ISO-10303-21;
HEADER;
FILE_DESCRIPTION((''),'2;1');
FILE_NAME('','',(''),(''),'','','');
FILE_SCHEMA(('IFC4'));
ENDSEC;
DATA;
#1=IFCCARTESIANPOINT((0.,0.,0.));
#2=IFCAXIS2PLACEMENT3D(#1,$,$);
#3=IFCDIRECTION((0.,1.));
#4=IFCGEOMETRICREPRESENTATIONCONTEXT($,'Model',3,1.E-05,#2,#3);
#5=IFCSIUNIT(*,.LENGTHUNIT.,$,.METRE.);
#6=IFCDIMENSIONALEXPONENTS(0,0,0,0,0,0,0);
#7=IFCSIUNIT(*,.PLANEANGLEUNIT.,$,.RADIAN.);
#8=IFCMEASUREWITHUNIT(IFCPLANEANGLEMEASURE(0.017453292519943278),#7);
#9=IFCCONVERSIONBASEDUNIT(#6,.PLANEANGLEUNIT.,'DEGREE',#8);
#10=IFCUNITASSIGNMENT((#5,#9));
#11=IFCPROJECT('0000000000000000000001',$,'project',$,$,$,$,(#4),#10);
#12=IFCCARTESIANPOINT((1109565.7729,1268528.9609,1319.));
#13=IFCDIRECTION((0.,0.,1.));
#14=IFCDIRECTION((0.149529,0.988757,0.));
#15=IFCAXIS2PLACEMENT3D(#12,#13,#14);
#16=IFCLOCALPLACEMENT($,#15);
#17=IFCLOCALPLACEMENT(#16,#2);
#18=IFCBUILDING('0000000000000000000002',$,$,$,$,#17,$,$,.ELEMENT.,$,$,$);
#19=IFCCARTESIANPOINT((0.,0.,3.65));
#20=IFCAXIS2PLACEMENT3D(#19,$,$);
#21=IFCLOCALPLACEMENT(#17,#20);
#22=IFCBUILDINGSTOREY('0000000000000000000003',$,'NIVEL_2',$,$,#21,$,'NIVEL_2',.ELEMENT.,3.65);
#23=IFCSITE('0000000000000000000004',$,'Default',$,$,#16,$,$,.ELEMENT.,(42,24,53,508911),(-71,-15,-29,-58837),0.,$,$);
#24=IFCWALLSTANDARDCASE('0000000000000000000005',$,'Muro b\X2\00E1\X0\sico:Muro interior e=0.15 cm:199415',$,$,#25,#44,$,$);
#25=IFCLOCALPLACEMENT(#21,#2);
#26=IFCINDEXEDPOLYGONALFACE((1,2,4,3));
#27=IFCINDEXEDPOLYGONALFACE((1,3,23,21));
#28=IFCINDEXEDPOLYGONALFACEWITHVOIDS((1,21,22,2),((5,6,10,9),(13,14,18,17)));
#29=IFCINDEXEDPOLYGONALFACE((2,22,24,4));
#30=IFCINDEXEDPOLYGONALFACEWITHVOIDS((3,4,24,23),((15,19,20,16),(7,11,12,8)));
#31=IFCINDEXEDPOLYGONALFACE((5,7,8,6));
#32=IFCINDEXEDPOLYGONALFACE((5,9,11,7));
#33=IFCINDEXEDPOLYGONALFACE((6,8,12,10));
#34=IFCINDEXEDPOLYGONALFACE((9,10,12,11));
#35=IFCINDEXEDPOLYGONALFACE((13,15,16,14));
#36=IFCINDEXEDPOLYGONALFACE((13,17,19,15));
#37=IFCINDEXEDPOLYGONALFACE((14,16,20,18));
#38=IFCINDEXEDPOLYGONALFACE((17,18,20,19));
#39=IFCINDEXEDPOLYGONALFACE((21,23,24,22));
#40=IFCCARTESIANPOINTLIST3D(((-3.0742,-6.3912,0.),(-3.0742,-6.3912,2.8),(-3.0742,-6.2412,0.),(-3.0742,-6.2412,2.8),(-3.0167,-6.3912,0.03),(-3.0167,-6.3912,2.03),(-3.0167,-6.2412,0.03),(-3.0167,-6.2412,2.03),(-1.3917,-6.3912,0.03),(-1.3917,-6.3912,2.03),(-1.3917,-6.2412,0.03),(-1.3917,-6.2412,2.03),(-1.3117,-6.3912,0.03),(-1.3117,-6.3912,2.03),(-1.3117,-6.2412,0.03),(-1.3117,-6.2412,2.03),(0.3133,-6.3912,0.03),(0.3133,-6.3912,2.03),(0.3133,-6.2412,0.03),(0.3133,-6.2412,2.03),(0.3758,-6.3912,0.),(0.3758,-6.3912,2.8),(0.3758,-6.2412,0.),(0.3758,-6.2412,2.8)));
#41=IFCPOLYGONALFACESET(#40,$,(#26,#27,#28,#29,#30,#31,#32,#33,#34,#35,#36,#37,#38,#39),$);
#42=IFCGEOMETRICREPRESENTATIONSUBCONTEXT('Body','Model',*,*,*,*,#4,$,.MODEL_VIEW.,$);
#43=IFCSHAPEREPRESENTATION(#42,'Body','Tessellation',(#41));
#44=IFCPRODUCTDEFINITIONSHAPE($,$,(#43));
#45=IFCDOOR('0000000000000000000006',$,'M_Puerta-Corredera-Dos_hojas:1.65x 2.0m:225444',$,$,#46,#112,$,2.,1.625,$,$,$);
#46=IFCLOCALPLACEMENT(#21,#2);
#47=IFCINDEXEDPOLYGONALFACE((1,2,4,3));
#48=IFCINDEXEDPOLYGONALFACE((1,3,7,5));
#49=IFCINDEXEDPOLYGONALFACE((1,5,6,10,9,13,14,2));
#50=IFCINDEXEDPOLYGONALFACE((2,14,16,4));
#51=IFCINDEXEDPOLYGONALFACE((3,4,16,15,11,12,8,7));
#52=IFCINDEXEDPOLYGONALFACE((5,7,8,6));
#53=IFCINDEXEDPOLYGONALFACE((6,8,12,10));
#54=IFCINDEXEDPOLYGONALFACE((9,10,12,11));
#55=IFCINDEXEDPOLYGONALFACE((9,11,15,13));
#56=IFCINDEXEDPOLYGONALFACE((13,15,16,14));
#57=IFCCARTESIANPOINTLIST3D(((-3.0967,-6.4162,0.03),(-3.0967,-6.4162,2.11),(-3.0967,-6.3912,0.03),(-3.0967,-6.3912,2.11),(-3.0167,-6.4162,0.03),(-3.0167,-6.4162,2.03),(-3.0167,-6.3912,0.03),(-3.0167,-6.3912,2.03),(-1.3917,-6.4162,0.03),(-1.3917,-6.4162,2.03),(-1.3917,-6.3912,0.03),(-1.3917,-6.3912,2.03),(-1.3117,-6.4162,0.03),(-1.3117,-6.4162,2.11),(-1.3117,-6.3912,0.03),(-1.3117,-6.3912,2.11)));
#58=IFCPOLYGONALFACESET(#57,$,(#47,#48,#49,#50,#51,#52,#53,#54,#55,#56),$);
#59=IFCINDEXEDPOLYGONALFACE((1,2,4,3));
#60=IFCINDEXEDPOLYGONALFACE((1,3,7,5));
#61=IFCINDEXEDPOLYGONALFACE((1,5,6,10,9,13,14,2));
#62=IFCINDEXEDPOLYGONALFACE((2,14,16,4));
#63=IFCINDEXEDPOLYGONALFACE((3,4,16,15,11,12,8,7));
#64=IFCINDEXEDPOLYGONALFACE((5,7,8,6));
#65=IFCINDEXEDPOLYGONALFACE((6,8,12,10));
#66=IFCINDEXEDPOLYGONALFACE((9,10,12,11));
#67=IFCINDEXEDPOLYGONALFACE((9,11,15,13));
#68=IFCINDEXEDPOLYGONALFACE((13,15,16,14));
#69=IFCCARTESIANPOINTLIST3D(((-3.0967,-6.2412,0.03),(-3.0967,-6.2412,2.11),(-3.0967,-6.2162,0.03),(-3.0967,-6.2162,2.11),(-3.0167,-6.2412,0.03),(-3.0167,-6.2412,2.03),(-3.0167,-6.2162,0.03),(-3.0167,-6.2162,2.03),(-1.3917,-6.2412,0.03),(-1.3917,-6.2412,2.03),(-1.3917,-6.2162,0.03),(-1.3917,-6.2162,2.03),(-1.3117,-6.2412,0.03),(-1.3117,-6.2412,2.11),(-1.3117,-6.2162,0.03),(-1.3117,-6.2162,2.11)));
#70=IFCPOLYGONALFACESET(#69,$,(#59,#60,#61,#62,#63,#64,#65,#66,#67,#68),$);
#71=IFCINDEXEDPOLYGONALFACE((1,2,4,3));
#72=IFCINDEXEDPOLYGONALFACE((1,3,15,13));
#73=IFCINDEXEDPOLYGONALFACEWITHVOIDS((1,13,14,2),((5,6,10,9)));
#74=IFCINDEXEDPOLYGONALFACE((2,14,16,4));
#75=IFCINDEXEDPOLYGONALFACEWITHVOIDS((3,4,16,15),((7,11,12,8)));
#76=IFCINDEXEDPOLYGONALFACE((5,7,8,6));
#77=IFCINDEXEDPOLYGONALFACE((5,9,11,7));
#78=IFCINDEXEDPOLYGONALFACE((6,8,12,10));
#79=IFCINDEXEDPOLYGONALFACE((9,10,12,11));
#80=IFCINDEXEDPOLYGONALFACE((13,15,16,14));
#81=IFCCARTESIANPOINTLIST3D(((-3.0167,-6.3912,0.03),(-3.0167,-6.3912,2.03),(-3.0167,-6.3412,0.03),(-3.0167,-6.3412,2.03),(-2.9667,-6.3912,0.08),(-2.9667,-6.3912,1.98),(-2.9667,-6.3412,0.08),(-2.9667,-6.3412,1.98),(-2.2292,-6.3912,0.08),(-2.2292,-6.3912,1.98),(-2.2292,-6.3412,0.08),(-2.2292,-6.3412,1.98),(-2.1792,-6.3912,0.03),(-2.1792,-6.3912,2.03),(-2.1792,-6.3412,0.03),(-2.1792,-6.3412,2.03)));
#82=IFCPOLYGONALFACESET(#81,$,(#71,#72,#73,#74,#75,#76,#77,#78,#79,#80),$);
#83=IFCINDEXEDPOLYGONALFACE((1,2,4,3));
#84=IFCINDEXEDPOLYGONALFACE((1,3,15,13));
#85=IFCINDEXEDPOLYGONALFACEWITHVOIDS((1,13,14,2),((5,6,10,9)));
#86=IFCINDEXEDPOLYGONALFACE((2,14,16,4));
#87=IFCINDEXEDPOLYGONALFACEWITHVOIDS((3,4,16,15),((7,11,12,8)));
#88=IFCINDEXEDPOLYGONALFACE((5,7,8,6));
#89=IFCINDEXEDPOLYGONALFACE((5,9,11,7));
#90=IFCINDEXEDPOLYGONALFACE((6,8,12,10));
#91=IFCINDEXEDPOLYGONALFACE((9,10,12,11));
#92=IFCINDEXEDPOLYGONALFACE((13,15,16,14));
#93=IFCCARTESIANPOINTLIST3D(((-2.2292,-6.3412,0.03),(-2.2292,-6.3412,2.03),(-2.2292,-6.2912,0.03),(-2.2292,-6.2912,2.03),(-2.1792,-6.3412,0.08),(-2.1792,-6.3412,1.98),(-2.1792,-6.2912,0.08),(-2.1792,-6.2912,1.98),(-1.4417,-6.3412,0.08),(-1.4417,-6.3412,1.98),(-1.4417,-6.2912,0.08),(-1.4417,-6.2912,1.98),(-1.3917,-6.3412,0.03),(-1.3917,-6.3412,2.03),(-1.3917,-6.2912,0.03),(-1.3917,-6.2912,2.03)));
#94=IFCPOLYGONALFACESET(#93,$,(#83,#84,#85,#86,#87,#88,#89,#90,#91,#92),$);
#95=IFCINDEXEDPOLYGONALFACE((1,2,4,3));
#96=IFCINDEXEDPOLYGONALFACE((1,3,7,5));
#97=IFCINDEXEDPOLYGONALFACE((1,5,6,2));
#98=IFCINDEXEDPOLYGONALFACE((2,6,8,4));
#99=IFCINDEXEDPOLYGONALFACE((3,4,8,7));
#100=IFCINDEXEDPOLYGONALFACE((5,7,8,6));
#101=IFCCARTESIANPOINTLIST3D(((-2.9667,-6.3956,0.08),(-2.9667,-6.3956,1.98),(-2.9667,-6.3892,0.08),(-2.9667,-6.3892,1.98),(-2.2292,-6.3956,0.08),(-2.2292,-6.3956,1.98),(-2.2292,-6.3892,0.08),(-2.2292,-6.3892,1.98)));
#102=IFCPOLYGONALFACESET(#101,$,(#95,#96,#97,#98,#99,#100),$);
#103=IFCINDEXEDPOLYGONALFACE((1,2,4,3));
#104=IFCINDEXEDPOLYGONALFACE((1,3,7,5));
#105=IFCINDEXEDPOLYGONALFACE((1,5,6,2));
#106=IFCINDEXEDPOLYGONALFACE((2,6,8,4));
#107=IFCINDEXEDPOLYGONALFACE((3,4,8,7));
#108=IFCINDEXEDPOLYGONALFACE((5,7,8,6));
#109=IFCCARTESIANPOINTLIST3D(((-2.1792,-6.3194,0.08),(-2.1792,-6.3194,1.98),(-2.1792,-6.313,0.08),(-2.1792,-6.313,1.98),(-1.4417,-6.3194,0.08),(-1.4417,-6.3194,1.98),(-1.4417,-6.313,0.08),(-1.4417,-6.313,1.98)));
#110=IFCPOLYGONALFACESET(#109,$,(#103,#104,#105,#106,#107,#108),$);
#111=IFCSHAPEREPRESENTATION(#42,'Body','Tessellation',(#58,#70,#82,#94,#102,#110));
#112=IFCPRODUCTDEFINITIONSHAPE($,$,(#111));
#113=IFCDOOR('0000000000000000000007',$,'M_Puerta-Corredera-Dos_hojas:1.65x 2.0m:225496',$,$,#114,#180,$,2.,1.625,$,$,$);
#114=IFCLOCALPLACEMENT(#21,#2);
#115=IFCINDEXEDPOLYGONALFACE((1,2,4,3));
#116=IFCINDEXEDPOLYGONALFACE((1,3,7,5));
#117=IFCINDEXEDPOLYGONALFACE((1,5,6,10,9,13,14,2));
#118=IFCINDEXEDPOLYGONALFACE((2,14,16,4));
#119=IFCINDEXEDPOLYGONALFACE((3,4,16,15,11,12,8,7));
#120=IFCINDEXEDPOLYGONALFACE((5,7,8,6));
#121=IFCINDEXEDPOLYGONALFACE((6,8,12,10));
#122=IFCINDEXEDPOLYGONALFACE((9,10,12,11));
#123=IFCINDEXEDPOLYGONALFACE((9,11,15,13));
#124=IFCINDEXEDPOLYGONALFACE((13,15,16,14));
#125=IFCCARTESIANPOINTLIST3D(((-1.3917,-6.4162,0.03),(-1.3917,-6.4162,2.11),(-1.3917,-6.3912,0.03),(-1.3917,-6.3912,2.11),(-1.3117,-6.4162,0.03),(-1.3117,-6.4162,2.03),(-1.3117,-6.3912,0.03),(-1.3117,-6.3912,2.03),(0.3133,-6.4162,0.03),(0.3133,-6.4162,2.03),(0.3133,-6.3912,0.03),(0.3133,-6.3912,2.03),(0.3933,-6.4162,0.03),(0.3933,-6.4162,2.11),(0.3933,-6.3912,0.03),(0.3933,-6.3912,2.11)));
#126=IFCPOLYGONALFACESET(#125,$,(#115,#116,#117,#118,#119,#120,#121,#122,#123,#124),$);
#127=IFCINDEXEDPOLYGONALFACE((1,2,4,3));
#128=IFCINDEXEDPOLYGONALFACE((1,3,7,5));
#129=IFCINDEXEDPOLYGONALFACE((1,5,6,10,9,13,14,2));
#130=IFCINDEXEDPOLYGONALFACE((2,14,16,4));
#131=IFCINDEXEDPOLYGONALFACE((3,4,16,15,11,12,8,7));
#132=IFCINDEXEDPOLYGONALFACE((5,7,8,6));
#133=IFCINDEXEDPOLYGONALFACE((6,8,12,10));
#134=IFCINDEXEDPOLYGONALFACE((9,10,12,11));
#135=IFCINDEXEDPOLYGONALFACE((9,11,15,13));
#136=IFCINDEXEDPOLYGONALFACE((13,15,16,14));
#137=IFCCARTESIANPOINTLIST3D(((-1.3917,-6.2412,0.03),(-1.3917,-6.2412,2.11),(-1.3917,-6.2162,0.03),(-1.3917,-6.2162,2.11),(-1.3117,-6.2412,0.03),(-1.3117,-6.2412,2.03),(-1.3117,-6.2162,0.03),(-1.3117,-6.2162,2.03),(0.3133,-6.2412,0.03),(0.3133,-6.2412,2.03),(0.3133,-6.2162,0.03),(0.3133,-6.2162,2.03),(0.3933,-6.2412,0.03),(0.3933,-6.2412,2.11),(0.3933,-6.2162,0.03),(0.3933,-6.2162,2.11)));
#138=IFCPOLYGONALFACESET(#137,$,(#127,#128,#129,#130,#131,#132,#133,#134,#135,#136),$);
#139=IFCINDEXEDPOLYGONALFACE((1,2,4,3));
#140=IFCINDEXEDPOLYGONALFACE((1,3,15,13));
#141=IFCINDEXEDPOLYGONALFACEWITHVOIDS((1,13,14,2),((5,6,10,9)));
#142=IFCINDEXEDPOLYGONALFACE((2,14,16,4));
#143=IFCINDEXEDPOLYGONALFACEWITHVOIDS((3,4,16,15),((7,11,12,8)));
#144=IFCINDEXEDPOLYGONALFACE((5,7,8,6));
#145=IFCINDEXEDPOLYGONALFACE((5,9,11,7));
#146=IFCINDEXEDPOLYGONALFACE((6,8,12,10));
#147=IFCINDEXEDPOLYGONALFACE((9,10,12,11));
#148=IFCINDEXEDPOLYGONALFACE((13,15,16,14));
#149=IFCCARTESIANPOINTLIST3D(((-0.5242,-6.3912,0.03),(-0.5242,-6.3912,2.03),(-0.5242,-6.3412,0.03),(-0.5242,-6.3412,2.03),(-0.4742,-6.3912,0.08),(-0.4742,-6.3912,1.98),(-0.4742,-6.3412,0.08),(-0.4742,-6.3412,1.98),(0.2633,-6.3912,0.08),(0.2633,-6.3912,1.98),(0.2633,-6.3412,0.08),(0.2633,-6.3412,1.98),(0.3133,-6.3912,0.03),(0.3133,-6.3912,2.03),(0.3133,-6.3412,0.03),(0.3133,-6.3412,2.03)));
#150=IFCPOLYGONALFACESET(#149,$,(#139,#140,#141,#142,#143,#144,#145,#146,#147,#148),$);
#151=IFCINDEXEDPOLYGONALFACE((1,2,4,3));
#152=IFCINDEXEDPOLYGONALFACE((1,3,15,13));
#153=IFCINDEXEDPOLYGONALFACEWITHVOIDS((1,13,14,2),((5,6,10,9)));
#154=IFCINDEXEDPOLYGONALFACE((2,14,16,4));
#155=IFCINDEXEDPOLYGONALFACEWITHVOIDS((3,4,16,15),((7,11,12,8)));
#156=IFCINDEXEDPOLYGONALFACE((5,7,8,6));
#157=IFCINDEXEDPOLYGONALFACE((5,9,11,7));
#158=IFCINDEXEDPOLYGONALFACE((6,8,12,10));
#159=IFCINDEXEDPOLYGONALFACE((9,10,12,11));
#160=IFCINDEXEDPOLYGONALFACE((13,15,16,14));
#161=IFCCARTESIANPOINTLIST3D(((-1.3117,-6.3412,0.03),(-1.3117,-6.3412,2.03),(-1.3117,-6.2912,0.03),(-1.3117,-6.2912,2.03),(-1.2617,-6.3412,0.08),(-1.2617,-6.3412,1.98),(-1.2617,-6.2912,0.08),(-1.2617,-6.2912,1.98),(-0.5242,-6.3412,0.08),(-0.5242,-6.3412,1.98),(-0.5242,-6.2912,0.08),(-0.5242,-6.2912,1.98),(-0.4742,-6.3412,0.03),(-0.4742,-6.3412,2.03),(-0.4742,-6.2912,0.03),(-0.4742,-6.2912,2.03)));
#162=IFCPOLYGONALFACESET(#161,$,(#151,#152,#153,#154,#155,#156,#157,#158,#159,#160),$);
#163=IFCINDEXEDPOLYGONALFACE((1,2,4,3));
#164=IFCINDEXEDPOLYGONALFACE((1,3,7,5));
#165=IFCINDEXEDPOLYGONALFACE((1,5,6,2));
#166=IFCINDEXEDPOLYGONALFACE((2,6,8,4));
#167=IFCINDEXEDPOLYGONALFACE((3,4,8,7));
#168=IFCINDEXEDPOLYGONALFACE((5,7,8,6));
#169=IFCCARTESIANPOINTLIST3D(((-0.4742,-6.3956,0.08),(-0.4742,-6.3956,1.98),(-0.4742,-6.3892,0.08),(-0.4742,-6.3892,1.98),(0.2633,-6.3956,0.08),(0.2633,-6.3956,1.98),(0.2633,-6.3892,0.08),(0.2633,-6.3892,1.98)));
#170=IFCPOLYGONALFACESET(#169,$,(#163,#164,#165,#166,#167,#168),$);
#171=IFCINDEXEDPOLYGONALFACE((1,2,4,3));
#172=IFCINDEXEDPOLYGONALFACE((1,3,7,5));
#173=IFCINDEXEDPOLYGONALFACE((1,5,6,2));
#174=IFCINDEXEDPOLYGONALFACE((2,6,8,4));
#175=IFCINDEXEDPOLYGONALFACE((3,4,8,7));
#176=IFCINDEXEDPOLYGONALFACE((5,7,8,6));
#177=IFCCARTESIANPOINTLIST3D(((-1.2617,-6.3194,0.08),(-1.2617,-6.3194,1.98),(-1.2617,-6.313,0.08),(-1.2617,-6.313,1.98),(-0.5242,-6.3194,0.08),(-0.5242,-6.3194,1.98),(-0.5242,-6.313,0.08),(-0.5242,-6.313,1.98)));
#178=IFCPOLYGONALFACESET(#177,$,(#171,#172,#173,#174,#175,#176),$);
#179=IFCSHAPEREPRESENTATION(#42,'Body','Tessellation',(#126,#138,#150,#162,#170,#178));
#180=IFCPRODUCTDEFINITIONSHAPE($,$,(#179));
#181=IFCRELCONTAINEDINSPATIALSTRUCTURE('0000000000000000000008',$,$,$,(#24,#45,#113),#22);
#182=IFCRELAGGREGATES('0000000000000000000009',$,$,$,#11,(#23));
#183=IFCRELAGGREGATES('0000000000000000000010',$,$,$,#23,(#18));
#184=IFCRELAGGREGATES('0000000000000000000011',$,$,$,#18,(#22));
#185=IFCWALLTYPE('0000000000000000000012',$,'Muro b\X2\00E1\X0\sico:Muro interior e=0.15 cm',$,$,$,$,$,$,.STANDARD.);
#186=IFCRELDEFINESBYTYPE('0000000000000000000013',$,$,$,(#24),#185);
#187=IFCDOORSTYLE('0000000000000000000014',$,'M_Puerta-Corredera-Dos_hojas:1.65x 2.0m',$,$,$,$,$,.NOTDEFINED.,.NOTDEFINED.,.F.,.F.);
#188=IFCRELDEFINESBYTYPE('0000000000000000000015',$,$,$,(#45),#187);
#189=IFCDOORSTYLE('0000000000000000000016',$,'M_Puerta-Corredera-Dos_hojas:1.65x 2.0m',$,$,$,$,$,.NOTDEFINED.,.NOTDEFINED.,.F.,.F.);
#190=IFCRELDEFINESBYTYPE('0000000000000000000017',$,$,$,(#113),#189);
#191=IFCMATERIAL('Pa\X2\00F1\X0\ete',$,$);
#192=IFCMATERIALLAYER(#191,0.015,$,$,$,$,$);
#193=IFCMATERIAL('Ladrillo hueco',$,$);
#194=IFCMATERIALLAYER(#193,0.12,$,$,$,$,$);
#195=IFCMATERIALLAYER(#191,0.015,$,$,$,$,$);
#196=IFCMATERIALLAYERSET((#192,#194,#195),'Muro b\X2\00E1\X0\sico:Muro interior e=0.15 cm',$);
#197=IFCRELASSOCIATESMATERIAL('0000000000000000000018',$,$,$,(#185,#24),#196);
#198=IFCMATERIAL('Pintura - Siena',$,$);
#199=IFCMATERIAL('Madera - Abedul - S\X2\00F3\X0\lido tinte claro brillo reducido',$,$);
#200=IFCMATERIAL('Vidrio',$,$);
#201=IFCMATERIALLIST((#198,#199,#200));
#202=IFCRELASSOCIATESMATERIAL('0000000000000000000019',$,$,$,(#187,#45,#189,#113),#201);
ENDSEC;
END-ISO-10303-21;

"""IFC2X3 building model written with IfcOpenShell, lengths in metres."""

from ifc_helpers import new_model, entity, si_unit, converted_unit, direction, frame, frame_2d, origin, origin_2d_with_axis, place, context, subcontext, project, spatial, polyline, rectangle, outline, extrude, source, transform, mapped, material, material_list, layer, layer_set, layer_usage, type_object, type_shapes, element, fill, save


model = new_model("IFC2X3")

# Units and contexts
model_context = context("Model", 3, precision=1e-05, world=origin(), true_north=direction((0.0, 1.0)))
body_context = subcontext(model_context, "Body", "Model", "MODEL_VIEW")
ifc_project = project(units=[si_unit("LENGTHUNIT", "METRE"), converted_unit("PLANEANGLEUNIT", "DEGREE", entity("IfcPlaneAngleMeasure", 0.017453292519943278), si_unit("PLANEANGLEUNIT", "RADIAN"), dimensions=[0, 0, 0, 0, 0, 0, 0])], contexts=[model_context])

# Site, building, storey
site_placement = place(None, frame((1109565.7729, 1268528.9609, 1319.0), z_axis=(0.0, 0.0, 1.0), x_axis=(0.149529, 0.988757, 0.0)))
site = spatial("IfcSite", under=ifc_project, at=site_placement, Name="Default", CompositionType="ELEMENT", RefLatitude=(42, 24, 53, 508911), RefLongitude=(-71, -15, -29, -58837), RefElevation=0.0)
building_placement = place(site_placement, origin())
building = spatial("IfcBuilding", under=site, at=building_placement, CompositionType="ELEMENT")
storey_placement = place(building_placement, frame((0.0, 0.0, 3.65)))
storey = spatial("IfcBuildingStorey", under=building, at=storey_placement, Name="NIVEL_2", LongName="NIVEL_2", CompositionType="ELEMENT", Elevation=3.65)

# Shared definitions
ifc_material_1 = material(Name="Pañete")
ifc_layer_1 = layer(ifc_material_1, 0.015)
ifc_material_2 = material(Name="Ladrillo hueco")
ifc_layer_2 = layer(ifc_material_2, 0.12)
ifc_layer_3 = layer(ifc_material_1, 0.015)
ifc_layer_set_1 = layer_set([ifc_layer_1, ifc_layer_2, ifc_layer_3], Name="Muro básico:Muro interior e=0.15 cm")
wall_type_1 = type_object("IfcWallType", Name="Muro básico:Muro interior e=0.15 cm", PredefinedType="STANDARD", material=ifc_layer_set_1)

# Wall, openings, doors
ifc_layer_usage_1 = layer_usage(ifc_layer_set_1, "AXIS2", "NEGATIVE", 0.075)
wall_1_placement = place(storey_placement, frame((-3.0742, -6.3162, 0.0)))
wall_1 = element("IfcWallStandardCase", 1, at=wall_1_placement, inside=storey, type_object=wall_type_1, material=ifc_layer_usage_1, Name="Muro básico:Muro interior e=0.15 cm:199415", context=body_context, shape_type="SweptSolid", body=[
    extrude(rectangle(XDim=3.45, YDim=0.15, at=frame_2d((1.725, 0.0), x_axis=(-1.0, 0.0))), origin(), (0.0, 0.0, 1.0), 2.8),
])
opening_1_placement = place(wall_1_placement, frame((1.6825, 0.075, 0.03)))
opening_1 = element("IfcOpeningElement", 2, at=opening_1_placement, cuts=wall_1, ObjectType="Opening", context=body_context, shape_type="SweptSolid", body=[
    extrude(rectangle(XDim=2.0, YDim=1.625, at=frame_2d((1.0, 0.8125), x_axis=(-1.0, 0.0))), frame((0.0, 0.0, 0.0), z_axis=(0.0, -1.0, 0.0), x_axis=(0.0, 0.0, 1.0)), (0.0, 0.0, 1.0), 0.15),
])
opening_2_placement = place(wall_1_placement, frame((3.3875, 0.075, 0.03)))
opening_2 = element("IfcOpeningElement", 3, at=opening_2_placement, cuts=wall_1, ObjectType="Opening", context=body_context, shape_type="SweptSolid", body=[
    extrude(rectangle(XDim=2.0, YDim=1.625, at=frame_2d((1.0, 0.8125), x_axis=(-1.0, 0.0))), frame((0.0, 0.0, 0.0), z_axis=(0.0, -1.0, 0.0), x_axis=(0.0, 0.0, 1.0)), (0.0, 0.0, 1.0), 0.15),
])
ifc_material_3 = material(Name="Pintura - Siena")
ifc_material_4 = material(Name="Madera - Abedul - Sólido tinte claro brillo reducido")
ifc_material_5 = material(Name="Vidrio")
ifc_material_list_1 = material_list([ifc_material_3, ifc_material_4, ifc_material_5])
door_style_1 = type_object("IfcDoorStyle", Name="M_Puerta-Corredera-Dos_hojas:1.65x 2.0m", ConstructionType="NOTDEFINED", OperationType="NOTDEFINED", ParameterTakesPrecedence=False, Sizeable=False, material=ifc_material_list_1)
shared_shape_1 = source(origin(), body_context, "Body", "SweptSolid", [
    extrude(outline(polyline([(-0.8925, -1.02), (-0.8125, -1.02), (-0.8125, 0.98), (0.8125, 0.98), (0.8125, -1.02), (0.8925, -1.02), (0.8925, 1.06), (-0.8925, 1.06), (-0.8925, -1.02)])), frame((0.8125, 0.429, 1.02), z_axis=(0.0, -1.0, 0.0), x_axis=(1.0, 0.0, 0.0)), (0.0, 0.0, 1.0), 0.025),
    extrude(outline(polyline([(-1.02, -0.8925), (1.06, -0.8925), (1.06, 0.8925), (-1.02, 0.8925), (-1.02, 0.8125), (0.98, 0.8125), (0.98, -0.8125), (-1.02, -0.8125), (-1.02, -0.8925)])), frame((0.8125, 0.254, 1.02), z_axis=(0.0, -1.0, 0.0), x_axis=(0.0, 0.0, 1.0)), (0.0, 0.0, 1.0), 0.025),
    extrude(outline(polyline([(-1.0, -0.4187), (1.0, -0.4187), (1.0, 0.4187), (-1.0, 0.4187), (-1.0, -0.4187)]), holes=[polyline([(-0.95, -0.3688), (-0.95, 0.3687), (0.95, 0.3687), (0.95, -0.3688), (-0.95, -0.3688)])]), frame((1.2063, 0.404, 1.0), z_axis=(0.0, -1.0, 0.0), x_axis=(0.0, 0.0, -1.0)), (0.0, 0.0, 1.0), 0.05),
    extrude(outline(polyline([(-0.4187, -1.0), (0.4187, -1.0), (0.4187, 1.0), (-0.4187, 1.0), (-0.4187, -1.0)]), holes=[polyline([(-0.3688, -0.95), (-0.3688, 0.95), (0.3688, 0.95), (0.3688, -0.95), (-0.3688, -0.95)])]), frame((0.4187, 0.354, 1.0), z_axis=(0.0, -1.0, 0.0), x_axis=(-1.0, 0.0, 0.0)), (0.0, 0.0, 1.0), 0.05),
    extrude(rectangle(XDim=0.7375, YDim=0.0064, at=origin_2d_with_axis()), frame((1.2062, 0.4052, 0.05)), (0.0, 0.0, 1.0), 1.9),
    extrude(rectangle(XDim=0.7375, YDim=0.0063, at=frame_2d((0.0, 0.0), x_axis=(1.0, 0.0))), frame((0.4187, 0.329, 0.05), z_axis=(0.0, 0.0, 1.0), x_axis=(-1.0, 0.0, 0.0)), (0.0, 0.0, 1.0), 1.9),
])
type_shapes(door_style_1, [shared_shape_1])
door_1_placement = place(opening_1_placement, frame((0.0, 0.254, 0.0), z_axis=(0.0, 0.0, 1.0), x_axis=(-1.0, 0.0, 0.0)))
door_1 = element("IfcDoor", 4, at=door_1_placement, inside=storey, type_object=door_style_1, material=ifc_material_list_1, Name="M_Puerta-Corredera-Dos_hojas:1.65x 2.0m:225444", OverallHeight=2.0, OverallWidth=1.625, context=body_context, shape_type="MappedRepresentation", body=[
    mapped(shared_shape_1, transform((0.0, 0.0, 0.0), scale=1.0)),
])
fill(opening_1, door_1)
door_style_2 = type_object("IfcDoorStyle", Name="M_Puerta-Corredera-Dos_hojas:1.65x 2.0m", ConstructionType="NOTDEFINED", OperationType="NOTDEFINED", ParameterTakesPrecedence=False, Sizeable=False, material=ifc_material_list_1)
shared_shape_2 = source(origin(), body_context, "Body", "SweptSolid", [
    extrude(outline(polyline([(-0.8925, -1.02), (-0.8125, -1.02), (-0.8125, 0.98), (0.8125, 0.98), (0.8125, -1.02), (0.8925, -1.02), (0.8925, 1.06), (-0.8925, 1.06), (-0.8925, -1.02)])), frame((0.8125, 0.15, 1.02), z_axis=(0.0, 1.0, 0.0), x_axis=(-1.0, 0.0, 0.0)), (0.0, 0.0, 1.0), 0.025),
    extrude(outline(polyline([(-1.02, -0.8925), (1.06, -0.8925), (1.06, 0.8925), (-1.02, 0.8925), (-1.02, 0.8125), (0.98, 0.8125), (0.98, -0.8125), (-1.02, -0.8125), (-1.02, -0.8925)])), frame((0.8125, -0.025, 1.02), z_axis=(0.0, 1.0, 0.0), x_axis=(0.0, 0.0, 1.0)), (0.0, 0.0, 1.0), 0.025),
    extrude(outline(polyline([(-1.0, -0.4187), (1.0, -0.4187), (1.0, 0.4187), (-1.0, 0.4187), (-1.0, -0.4187)]), holes=[polyline([(-0.95, -0.3688), (-0.95, 0.3687), (0.95, 0.3687), (0.95, -0.3688), (-0.95, -0.3688)])]), frame((0.4188, 0.1, 1.0), z_axis=(0.0, 1.0, 0.0), x_axis=(0.0, 0.0, -1.0)), (0.0, 0.0, 1.0), 0.05),
    extrude(outline(polyline([(-0.4187, -1.0), (0.4187, -1.0), (0.4187, 1.0), (-0.4187, 1.0), (-0.4187, -1.0)]), holes=[polyline([(-0.3688, -0.95), (-0.3688, 0.95), (0.3688, 0.95), (0.3688, -0.95), (-0.3688, -0.95)])]), frame((1.2063, 0.05, 1.0), z_axis=(0.0, 1.0, 0.0), x_axis=(1.0, 0.0, 0.0)), (0.0, 0.0, 1.0), 0.05),
    extrude(rectangle(XDim=0.0064, YDim=0.7375, at=origin_2d_with_axis()), frame((0.4188, 0.1512, 0.05), z_axis=(0.0, 0.0, 1.0), x_axis=(0.0, 1.0, 0.0)), (0.0, 0.0, 1.0), 1.9),
    extrude(rectangle(XDim=0.0063, YDim=0.7375, at=frame_2d((0.0, 0.0), x_axis=(1.0, 0.0))), frame((1.2063, 0.075, 0.05), z_axis=(0.0, 0.0, 1.0), x_axis=(0.0, -1.0, 0.0)), (0.0, 0.0, 1.0), 1.9),
])
type_shapes(door_style_2, [shared_shape_2])
door_2_placement = place(opening_2_placement, frame((0.0, 0.0, 0.0), z_axis=(0.0, 0.0, 1.0), x_axis=(-1.0, 0.0, 0.0)))
door_2 = element("IfcDoor", 5, at=door_2_placement, inside=storey, type_object=door_style_2, material=ifc_material_list_1, Name="M_Puerta-Corredera-Dos_hojas:1.65x 2.0m:225496", OverallHeight=2.0, OverallWidth=1.625, context=body_context, shape_type="MappedRepresentation", body=[
    mapped(shared_shape_2, transform((0.0, 0.0, 0.0), scale=1.0)),
])
fill(opening_2, door_2)

save(model, "model.ifc")
